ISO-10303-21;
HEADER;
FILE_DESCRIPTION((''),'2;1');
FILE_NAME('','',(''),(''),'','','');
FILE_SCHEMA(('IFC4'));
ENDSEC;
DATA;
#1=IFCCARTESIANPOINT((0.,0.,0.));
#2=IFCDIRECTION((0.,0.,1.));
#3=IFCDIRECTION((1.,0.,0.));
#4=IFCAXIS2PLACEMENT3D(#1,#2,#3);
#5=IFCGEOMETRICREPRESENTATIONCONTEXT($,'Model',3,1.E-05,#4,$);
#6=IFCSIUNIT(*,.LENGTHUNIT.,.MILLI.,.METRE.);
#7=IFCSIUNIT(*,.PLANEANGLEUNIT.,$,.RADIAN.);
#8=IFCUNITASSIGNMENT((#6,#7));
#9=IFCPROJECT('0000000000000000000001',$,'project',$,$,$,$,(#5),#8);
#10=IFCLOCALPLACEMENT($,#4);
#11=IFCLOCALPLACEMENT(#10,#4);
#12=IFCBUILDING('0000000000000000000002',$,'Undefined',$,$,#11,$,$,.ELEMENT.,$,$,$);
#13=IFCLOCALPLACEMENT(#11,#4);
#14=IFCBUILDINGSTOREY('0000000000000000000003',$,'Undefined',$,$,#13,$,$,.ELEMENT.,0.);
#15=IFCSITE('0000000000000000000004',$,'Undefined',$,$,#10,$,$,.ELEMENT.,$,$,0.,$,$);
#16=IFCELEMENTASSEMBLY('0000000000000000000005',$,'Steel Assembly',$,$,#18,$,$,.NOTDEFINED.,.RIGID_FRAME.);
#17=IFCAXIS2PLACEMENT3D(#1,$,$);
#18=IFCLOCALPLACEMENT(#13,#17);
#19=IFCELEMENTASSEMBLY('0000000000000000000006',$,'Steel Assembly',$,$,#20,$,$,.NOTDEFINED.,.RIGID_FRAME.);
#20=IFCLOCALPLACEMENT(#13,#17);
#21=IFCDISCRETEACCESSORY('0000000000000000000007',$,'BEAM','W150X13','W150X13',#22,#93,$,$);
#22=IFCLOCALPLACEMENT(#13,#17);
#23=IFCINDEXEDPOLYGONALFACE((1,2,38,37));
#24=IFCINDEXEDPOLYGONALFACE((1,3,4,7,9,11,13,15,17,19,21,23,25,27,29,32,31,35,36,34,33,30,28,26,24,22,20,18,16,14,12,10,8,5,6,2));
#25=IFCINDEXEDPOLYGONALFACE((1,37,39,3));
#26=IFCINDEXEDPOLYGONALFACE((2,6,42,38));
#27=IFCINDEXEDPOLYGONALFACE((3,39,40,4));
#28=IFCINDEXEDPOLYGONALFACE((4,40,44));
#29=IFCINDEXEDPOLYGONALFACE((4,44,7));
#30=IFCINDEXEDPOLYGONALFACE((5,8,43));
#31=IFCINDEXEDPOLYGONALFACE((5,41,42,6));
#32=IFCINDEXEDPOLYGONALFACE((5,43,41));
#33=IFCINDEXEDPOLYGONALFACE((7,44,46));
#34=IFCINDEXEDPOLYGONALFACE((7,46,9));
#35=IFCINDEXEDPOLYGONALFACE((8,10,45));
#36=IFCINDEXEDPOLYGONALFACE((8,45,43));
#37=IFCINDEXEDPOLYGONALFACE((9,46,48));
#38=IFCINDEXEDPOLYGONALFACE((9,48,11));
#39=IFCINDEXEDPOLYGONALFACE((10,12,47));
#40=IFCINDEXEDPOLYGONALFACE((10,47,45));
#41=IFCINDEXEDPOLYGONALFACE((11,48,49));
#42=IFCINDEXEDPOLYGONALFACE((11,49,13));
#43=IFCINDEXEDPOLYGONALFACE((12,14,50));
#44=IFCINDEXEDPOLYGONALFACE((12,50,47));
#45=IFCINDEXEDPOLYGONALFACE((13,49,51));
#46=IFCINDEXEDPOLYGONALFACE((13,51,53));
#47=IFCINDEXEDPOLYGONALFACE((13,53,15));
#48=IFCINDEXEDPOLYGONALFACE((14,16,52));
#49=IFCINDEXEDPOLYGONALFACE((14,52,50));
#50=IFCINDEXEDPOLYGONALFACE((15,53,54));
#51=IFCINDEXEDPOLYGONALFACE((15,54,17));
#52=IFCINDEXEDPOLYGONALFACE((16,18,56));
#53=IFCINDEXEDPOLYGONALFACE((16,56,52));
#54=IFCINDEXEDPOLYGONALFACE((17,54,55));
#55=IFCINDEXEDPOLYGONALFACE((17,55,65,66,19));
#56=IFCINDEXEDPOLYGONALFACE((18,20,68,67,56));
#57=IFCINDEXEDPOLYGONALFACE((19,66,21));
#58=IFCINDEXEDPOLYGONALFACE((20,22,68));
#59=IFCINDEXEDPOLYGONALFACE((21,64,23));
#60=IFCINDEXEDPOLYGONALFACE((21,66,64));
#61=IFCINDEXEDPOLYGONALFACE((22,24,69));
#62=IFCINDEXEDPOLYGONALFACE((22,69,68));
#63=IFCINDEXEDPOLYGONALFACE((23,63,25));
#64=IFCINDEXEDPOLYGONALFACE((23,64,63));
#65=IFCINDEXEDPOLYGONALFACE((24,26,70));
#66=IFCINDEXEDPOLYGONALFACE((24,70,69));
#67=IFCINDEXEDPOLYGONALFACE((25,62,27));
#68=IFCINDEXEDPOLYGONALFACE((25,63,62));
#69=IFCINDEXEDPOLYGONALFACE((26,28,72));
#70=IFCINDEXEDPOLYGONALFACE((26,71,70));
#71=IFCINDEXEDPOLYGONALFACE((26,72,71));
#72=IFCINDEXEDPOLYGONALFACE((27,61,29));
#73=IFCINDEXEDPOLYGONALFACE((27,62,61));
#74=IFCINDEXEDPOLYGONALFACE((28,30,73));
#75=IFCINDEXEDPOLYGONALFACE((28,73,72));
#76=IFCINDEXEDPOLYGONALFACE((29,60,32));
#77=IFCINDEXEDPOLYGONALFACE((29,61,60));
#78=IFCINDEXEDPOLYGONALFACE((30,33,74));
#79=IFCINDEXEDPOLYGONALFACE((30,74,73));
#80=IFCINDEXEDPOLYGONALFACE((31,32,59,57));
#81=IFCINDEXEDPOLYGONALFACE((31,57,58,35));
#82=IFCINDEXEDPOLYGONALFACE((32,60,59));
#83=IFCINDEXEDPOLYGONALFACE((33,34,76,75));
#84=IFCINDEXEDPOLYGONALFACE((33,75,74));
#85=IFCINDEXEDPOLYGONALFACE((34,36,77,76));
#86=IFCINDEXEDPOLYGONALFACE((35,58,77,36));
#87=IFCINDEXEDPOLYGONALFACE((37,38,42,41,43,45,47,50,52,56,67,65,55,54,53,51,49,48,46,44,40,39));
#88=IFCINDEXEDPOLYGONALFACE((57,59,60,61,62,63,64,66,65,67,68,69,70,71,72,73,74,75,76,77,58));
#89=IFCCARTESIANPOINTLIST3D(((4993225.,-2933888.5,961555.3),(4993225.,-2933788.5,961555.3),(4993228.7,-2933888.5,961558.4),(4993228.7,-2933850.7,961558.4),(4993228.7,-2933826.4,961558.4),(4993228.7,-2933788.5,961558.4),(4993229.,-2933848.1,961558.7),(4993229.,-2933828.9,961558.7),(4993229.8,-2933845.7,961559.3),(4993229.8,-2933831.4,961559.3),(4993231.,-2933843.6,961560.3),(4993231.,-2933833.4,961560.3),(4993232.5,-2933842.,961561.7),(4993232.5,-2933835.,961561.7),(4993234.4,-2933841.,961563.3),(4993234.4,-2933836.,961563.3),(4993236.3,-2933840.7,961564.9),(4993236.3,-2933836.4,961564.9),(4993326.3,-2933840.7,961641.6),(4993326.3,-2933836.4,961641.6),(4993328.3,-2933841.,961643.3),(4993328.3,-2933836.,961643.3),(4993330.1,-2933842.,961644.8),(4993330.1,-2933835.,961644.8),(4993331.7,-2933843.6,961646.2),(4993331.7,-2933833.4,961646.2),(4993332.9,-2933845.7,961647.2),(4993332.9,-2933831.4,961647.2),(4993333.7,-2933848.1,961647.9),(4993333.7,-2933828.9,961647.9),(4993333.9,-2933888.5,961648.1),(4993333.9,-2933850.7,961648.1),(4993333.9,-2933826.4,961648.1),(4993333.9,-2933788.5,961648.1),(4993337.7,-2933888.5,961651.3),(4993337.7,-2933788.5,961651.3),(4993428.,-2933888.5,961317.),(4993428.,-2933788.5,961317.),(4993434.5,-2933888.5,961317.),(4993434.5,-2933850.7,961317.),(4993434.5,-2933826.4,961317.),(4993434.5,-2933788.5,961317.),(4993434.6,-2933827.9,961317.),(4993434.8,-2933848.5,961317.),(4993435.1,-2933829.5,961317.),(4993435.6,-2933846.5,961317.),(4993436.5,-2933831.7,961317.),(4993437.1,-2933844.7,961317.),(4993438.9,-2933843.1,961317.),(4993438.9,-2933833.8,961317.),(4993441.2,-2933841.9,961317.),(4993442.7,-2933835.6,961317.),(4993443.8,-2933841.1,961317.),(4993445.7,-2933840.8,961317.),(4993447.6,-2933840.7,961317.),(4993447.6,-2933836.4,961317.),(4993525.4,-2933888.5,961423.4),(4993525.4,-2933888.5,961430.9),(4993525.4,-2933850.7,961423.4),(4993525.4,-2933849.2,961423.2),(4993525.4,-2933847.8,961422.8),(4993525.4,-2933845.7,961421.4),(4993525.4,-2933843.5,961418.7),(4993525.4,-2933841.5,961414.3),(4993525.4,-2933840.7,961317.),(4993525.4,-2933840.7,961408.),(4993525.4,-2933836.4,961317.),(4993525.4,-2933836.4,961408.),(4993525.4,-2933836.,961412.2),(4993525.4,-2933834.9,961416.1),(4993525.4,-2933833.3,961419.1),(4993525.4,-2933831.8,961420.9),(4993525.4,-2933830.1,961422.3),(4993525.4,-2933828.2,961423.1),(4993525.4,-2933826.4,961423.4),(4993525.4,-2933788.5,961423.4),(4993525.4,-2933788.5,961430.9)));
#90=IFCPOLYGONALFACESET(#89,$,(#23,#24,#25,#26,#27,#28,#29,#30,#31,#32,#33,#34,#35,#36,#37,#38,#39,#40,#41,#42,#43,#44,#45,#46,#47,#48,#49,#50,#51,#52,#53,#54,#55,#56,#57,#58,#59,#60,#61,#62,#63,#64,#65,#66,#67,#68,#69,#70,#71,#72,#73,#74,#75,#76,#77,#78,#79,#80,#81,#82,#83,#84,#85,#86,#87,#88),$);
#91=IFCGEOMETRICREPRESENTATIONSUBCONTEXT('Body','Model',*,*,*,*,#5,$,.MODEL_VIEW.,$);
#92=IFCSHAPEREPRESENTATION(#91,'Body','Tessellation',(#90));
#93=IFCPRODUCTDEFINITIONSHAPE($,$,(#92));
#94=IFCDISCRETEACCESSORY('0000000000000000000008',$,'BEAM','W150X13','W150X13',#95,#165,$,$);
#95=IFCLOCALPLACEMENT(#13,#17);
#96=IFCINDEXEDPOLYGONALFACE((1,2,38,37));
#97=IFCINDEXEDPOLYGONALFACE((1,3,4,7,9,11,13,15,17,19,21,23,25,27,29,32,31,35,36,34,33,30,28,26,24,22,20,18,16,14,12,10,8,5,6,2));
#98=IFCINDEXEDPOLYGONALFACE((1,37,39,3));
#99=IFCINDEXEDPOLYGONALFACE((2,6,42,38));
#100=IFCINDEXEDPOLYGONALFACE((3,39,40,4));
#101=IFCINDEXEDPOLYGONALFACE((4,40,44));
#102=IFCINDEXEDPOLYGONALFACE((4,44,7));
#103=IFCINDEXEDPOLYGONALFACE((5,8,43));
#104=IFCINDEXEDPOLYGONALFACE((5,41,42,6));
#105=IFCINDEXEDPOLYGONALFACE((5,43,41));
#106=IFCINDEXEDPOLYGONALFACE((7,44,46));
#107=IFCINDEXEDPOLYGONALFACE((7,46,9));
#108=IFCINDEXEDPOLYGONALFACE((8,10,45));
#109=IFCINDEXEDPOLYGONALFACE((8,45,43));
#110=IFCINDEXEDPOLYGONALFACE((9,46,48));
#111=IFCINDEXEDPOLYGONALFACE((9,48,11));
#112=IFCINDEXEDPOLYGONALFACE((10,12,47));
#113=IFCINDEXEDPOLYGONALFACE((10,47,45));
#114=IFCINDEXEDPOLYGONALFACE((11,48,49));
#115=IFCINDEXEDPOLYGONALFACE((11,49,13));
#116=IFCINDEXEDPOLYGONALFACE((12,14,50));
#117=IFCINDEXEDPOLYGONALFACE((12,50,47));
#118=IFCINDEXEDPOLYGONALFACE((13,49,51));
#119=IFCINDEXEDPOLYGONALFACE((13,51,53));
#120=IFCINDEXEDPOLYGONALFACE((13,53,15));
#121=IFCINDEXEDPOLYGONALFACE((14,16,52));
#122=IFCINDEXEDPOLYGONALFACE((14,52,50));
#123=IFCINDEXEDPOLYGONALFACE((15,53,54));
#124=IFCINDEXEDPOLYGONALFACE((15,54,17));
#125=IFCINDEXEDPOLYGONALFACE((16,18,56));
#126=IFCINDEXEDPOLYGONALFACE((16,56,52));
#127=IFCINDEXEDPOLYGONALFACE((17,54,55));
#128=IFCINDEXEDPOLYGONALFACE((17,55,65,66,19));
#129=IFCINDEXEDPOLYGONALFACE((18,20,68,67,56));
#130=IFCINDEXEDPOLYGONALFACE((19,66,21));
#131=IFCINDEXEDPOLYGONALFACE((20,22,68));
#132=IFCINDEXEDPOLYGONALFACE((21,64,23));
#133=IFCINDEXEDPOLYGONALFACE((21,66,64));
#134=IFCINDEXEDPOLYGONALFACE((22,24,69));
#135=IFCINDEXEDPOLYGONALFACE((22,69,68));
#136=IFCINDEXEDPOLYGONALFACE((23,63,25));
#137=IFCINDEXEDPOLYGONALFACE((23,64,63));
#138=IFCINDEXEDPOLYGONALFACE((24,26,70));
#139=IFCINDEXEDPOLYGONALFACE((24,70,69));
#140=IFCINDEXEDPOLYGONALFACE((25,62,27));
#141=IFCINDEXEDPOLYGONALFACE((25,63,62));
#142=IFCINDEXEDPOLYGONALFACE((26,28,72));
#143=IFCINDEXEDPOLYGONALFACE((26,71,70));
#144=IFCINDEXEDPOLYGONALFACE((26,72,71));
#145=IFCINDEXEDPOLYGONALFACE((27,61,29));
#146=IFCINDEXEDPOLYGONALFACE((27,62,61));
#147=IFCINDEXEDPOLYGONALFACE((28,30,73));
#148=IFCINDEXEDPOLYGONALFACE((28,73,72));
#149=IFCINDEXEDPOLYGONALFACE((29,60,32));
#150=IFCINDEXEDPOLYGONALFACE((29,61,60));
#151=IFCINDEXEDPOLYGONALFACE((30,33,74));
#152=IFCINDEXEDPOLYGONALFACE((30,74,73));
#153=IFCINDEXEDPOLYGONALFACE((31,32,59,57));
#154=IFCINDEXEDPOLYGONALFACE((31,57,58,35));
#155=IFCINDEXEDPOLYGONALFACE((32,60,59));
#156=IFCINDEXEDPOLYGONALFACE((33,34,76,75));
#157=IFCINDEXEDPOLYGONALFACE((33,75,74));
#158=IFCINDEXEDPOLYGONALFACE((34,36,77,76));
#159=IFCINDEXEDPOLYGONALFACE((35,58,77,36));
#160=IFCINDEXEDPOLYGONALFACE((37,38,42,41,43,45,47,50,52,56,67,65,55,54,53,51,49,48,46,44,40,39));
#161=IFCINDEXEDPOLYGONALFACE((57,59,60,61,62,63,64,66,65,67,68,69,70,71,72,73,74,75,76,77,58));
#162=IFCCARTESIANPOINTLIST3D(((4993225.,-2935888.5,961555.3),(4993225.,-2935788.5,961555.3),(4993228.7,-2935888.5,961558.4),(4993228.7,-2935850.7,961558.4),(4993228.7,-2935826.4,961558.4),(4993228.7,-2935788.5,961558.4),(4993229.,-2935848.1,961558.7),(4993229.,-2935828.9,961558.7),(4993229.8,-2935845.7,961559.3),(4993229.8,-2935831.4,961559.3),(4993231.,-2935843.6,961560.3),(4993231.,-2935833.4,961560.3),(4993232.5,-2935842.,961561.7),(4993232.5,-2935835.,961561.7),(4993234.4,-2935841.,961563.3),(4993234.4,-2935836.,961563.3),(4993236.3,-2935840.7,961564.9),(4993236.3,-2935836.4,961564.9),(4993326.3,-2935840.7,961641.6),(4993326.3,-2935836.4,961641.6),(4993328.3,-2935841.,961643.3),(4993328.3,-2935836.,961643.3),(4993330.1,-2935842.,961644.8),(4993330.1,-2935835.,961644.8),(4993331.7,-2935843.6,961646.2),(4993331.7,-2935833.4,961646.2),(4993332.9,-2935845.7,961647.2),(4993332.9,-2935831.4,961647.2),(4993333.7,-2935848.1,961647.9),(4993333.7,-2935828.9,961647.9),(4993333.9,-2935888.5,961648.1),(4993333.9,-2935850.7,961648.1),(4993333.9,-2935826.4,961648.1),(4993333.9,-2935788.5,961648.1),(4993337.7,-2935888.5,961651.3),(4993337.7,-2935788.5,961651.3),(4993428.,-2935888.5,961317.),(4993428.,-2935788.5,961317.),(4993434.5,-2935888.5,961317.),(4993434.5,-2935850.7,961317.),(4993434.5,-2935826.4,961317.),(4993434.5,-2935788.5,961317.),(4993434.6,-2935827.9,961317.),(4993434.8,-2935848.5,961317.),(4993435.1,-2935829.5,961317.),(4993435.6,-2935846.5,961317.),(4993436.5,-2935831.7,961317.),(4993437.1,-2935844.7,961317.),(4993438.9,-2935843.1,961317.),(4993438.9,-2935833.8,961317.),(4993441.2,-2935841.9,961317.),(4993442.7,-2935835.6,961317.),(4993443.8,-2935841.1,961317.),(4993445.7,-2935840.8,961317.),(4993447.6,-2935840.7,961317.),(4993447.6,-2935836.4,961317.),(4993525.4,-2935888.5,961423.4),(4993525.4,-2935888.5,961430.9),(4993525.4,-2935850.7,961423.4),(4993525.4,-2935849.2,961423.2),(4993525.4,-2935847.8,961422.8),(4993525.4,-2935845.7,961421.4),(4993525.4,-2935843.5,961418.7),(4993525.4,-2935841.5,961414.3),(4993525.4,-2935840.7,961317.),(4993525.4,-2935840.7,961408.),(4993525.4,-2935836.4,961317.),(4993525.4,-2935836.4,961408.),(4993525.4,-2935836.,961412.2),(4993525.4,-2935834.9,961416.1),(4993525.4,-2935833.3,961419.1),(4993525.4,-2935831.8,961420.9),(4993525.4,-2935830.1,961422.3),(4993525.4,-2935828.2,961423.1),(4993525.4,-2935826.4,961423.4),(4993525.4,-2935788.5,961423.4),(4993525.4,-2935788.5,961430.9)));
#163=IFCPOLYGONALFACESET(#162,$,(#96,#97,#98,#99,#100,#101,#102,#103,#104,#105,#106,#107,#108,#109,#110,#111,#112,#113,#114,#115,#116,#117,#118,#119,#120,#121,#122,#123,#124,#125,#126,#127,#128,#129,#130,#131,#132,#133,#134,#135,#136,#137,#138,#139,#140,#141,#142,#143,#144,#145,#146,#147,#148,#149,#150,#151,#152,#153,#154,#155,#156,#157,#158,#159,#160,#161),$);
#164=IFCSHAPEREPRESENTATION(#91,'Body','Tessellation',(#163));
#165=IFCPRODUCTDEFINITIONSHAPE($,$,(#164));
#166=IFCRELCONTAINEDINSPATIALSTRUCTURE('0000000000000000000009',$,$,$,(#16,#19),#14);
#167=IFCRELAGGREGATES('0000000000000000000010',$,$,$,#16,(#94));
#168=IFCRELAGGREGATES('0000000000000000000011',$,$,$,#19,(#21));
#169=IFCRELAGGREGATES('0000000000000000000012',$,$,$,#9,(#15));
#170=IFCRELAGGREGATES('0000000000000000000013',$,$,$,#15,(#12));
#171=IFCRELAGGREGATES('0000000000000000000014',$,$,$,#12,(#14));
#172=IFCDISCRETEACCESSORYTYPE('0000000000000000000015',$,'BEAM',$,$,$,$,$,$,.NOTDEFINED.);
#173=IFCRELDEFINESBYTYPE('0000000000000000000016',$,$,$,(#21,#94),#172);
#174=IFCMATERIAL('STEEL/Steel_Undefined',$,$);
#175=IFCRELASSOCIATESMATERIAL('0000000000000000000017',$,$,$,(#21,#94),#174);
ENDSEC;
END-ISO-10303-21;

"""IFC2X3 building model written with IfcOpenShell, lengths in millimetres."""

from ifc_helpers import new_model, si_unit, frame, origin_with_axes, origin_2d_with_axis, place, context, subcontext, project, spatial, i_section, extrude, clip, halfspace, material, type_object, element, aggregate, save


model = new_model("IFC2X3")

# Units and contexts
model_context = context("Model", 3, precision=1e-05, world=origin_with_axes())
body_context = subcontext(model_context, "Body", "Model", "MODEL_VIEW")
ifc_project = project(units=[si_unit("LENGTHUNIT", "METRE", prefix="MILLI"), si_unit("PLANEANGLEUNIT", "RADIAN")], contexts=[model_context])

# Site, building, storey
site_placement = place(None, origin_with_axes())
site = spatial("IfcSite", under=ifc_project, at=site_placement, Name="Undefined", CompositionType="ELEMENT", RefElevation=0.0)
building_placement = place(site_placement, origin_with_axes())
building = spatial("IfcBuilding", under=site, at=building_placement, Name="Undefined", CompositionType="ELEMENT")
storey_placement = place(building_placement, origin_with_axes())
storey = spatial("IfcBuildingStorey", under=building, at=storey_placement, Name="Undefined", CompositionType="ELEMENT", Elevation=0.0)

# Shared definitions
ifc_material_1 = material(Name="STEEL/Steel_Undefined")

# Element assembly
assembly_1_placement = place(storey_placement, origin_with_axes())
assembly_1 = element("IfcElementAssembly", 1, at=assembly_1_placement, inside=storey, Name="Steel Assembly", AssemblyPlace="NOTDEFINED", PredefinedType="RIGID_FRAME")

# Element assembly
assembly_2_placement = place(storey_placement, origin_with_axes())
assembly_2 = element("IfcElementAssembly", 2, at=assembly_2_placement, inside=storey, Name="Steel Assembly", AssemblyPlace="NOTDEFINED", PredefinedType="RIGID_FRAME")

# Discrete accessories
discrete_accessory_type_1 = type_object("IfcDiscreteAccessoryType", Name="BEAM")
discrete_accessory_1_placement = place(assembly_2_placement, frame((4993861.1, -2933838.5, 960922.9), z_axis=(-0.761138, 0.0, -0.64859), x_axis=(-0.64859, 0.0, 0.761138)))
discrete_accessory_1 = element("IfcDiscreteAccessory", 3, at=discrete_accessory_1_placement, type_object=discrete_accessory_type_1, material=ifc_material_1, Name="BEAM", Description="W150X13", ObjectType="W150X13", context=body_context, shape_type="Clipping", body=[
    clip(clip(clip(extrude(i_section(OverallWidth=100.0, OverallDepth=148.0, WebThickness=4.3, FlangeThickness=4.9, FilletRadius=10.0, at=origin_2d_with_axis()), frame((967.8, 0.0, 0.0), z_axis=(-1.0, 0.0, 0.0), x_axis=(0.0, -1.0, 0.0)), (0.0, 0.0, 1.0), 967.8), halfspace(frame((454.7, 50.0, -74.0), z_axis=(-0.761138, 0.0, 0.64859), x_axis=(0.64859, 0.0, 0.761138)), False)), halfspace(frame((430.7, -50.0, 74.0), z_axis=(-0.64859, 0.0, -0.761138), x_axis=(0.761138, 0.0, -0.64859)), False)), halfspace(frame((893.9, 0.0, -74.0), z_axis=(-1.0, 0.0, 0.0), x_axis=(0.0, 1.0, 0.0)), True)),
])
discrete_accessory_2_placement = place(assembly_1_placement, frame((4993861.1, -2935838.5, 960922.9), z_axis=(-0.761138, 0.0, -0.64859), x_axis=(-0.64859, 0.0, 0.761138)))
discrete_accessory_2 = element("IfcDiscreteAccessory", 4, at=discrete_accessory_2_placement, type_object=discrete_accessory_type_1, material=ifc_material_1, Name="BEAM", Description="W150X13", ObjectType="W150X13", context=body_context, shape_type="Clipping", body=[
    clip(clip(clip(extrude(i_section(OverallWidth=100.0, OverallDepth=148.0, WebThickness=4.3, FlangeThickness=4.9, FilletRadius=10.0, at=origin_2d_with_axis()), frame((967.8, 0.0, 0.0), z_axis=(-1.0, 0.0, 0.0), x_axis=(0.0, -1.0, 0.0)), (0.0, 0.0, 1.0), 967.8), halfspace(frame((454.7, 50.0, -74.0), z_axis=(-0.761138, 0.0, 0.64859), x_axis=(0.64859, 0.0, 0.761138)), False)), halfspace(frame((430.7, -50.0, 74.0), z_axis=(-0.64859, 0.0, -0.761138), x_axis=(0.761138, 0.0, -0.64859)), False)), halfspace(frame((893.9, 0.0, -74.0), z_axis=(-1.0, 0.0, 0.0), x_axis=(0.0, 1.0, 0.0)), True)),
])
aggregate(assembly_1, [discrete_accessory_2])
aggregate(assembly_2, [discrete_accessory_1])

save(model, "model.ifc")
